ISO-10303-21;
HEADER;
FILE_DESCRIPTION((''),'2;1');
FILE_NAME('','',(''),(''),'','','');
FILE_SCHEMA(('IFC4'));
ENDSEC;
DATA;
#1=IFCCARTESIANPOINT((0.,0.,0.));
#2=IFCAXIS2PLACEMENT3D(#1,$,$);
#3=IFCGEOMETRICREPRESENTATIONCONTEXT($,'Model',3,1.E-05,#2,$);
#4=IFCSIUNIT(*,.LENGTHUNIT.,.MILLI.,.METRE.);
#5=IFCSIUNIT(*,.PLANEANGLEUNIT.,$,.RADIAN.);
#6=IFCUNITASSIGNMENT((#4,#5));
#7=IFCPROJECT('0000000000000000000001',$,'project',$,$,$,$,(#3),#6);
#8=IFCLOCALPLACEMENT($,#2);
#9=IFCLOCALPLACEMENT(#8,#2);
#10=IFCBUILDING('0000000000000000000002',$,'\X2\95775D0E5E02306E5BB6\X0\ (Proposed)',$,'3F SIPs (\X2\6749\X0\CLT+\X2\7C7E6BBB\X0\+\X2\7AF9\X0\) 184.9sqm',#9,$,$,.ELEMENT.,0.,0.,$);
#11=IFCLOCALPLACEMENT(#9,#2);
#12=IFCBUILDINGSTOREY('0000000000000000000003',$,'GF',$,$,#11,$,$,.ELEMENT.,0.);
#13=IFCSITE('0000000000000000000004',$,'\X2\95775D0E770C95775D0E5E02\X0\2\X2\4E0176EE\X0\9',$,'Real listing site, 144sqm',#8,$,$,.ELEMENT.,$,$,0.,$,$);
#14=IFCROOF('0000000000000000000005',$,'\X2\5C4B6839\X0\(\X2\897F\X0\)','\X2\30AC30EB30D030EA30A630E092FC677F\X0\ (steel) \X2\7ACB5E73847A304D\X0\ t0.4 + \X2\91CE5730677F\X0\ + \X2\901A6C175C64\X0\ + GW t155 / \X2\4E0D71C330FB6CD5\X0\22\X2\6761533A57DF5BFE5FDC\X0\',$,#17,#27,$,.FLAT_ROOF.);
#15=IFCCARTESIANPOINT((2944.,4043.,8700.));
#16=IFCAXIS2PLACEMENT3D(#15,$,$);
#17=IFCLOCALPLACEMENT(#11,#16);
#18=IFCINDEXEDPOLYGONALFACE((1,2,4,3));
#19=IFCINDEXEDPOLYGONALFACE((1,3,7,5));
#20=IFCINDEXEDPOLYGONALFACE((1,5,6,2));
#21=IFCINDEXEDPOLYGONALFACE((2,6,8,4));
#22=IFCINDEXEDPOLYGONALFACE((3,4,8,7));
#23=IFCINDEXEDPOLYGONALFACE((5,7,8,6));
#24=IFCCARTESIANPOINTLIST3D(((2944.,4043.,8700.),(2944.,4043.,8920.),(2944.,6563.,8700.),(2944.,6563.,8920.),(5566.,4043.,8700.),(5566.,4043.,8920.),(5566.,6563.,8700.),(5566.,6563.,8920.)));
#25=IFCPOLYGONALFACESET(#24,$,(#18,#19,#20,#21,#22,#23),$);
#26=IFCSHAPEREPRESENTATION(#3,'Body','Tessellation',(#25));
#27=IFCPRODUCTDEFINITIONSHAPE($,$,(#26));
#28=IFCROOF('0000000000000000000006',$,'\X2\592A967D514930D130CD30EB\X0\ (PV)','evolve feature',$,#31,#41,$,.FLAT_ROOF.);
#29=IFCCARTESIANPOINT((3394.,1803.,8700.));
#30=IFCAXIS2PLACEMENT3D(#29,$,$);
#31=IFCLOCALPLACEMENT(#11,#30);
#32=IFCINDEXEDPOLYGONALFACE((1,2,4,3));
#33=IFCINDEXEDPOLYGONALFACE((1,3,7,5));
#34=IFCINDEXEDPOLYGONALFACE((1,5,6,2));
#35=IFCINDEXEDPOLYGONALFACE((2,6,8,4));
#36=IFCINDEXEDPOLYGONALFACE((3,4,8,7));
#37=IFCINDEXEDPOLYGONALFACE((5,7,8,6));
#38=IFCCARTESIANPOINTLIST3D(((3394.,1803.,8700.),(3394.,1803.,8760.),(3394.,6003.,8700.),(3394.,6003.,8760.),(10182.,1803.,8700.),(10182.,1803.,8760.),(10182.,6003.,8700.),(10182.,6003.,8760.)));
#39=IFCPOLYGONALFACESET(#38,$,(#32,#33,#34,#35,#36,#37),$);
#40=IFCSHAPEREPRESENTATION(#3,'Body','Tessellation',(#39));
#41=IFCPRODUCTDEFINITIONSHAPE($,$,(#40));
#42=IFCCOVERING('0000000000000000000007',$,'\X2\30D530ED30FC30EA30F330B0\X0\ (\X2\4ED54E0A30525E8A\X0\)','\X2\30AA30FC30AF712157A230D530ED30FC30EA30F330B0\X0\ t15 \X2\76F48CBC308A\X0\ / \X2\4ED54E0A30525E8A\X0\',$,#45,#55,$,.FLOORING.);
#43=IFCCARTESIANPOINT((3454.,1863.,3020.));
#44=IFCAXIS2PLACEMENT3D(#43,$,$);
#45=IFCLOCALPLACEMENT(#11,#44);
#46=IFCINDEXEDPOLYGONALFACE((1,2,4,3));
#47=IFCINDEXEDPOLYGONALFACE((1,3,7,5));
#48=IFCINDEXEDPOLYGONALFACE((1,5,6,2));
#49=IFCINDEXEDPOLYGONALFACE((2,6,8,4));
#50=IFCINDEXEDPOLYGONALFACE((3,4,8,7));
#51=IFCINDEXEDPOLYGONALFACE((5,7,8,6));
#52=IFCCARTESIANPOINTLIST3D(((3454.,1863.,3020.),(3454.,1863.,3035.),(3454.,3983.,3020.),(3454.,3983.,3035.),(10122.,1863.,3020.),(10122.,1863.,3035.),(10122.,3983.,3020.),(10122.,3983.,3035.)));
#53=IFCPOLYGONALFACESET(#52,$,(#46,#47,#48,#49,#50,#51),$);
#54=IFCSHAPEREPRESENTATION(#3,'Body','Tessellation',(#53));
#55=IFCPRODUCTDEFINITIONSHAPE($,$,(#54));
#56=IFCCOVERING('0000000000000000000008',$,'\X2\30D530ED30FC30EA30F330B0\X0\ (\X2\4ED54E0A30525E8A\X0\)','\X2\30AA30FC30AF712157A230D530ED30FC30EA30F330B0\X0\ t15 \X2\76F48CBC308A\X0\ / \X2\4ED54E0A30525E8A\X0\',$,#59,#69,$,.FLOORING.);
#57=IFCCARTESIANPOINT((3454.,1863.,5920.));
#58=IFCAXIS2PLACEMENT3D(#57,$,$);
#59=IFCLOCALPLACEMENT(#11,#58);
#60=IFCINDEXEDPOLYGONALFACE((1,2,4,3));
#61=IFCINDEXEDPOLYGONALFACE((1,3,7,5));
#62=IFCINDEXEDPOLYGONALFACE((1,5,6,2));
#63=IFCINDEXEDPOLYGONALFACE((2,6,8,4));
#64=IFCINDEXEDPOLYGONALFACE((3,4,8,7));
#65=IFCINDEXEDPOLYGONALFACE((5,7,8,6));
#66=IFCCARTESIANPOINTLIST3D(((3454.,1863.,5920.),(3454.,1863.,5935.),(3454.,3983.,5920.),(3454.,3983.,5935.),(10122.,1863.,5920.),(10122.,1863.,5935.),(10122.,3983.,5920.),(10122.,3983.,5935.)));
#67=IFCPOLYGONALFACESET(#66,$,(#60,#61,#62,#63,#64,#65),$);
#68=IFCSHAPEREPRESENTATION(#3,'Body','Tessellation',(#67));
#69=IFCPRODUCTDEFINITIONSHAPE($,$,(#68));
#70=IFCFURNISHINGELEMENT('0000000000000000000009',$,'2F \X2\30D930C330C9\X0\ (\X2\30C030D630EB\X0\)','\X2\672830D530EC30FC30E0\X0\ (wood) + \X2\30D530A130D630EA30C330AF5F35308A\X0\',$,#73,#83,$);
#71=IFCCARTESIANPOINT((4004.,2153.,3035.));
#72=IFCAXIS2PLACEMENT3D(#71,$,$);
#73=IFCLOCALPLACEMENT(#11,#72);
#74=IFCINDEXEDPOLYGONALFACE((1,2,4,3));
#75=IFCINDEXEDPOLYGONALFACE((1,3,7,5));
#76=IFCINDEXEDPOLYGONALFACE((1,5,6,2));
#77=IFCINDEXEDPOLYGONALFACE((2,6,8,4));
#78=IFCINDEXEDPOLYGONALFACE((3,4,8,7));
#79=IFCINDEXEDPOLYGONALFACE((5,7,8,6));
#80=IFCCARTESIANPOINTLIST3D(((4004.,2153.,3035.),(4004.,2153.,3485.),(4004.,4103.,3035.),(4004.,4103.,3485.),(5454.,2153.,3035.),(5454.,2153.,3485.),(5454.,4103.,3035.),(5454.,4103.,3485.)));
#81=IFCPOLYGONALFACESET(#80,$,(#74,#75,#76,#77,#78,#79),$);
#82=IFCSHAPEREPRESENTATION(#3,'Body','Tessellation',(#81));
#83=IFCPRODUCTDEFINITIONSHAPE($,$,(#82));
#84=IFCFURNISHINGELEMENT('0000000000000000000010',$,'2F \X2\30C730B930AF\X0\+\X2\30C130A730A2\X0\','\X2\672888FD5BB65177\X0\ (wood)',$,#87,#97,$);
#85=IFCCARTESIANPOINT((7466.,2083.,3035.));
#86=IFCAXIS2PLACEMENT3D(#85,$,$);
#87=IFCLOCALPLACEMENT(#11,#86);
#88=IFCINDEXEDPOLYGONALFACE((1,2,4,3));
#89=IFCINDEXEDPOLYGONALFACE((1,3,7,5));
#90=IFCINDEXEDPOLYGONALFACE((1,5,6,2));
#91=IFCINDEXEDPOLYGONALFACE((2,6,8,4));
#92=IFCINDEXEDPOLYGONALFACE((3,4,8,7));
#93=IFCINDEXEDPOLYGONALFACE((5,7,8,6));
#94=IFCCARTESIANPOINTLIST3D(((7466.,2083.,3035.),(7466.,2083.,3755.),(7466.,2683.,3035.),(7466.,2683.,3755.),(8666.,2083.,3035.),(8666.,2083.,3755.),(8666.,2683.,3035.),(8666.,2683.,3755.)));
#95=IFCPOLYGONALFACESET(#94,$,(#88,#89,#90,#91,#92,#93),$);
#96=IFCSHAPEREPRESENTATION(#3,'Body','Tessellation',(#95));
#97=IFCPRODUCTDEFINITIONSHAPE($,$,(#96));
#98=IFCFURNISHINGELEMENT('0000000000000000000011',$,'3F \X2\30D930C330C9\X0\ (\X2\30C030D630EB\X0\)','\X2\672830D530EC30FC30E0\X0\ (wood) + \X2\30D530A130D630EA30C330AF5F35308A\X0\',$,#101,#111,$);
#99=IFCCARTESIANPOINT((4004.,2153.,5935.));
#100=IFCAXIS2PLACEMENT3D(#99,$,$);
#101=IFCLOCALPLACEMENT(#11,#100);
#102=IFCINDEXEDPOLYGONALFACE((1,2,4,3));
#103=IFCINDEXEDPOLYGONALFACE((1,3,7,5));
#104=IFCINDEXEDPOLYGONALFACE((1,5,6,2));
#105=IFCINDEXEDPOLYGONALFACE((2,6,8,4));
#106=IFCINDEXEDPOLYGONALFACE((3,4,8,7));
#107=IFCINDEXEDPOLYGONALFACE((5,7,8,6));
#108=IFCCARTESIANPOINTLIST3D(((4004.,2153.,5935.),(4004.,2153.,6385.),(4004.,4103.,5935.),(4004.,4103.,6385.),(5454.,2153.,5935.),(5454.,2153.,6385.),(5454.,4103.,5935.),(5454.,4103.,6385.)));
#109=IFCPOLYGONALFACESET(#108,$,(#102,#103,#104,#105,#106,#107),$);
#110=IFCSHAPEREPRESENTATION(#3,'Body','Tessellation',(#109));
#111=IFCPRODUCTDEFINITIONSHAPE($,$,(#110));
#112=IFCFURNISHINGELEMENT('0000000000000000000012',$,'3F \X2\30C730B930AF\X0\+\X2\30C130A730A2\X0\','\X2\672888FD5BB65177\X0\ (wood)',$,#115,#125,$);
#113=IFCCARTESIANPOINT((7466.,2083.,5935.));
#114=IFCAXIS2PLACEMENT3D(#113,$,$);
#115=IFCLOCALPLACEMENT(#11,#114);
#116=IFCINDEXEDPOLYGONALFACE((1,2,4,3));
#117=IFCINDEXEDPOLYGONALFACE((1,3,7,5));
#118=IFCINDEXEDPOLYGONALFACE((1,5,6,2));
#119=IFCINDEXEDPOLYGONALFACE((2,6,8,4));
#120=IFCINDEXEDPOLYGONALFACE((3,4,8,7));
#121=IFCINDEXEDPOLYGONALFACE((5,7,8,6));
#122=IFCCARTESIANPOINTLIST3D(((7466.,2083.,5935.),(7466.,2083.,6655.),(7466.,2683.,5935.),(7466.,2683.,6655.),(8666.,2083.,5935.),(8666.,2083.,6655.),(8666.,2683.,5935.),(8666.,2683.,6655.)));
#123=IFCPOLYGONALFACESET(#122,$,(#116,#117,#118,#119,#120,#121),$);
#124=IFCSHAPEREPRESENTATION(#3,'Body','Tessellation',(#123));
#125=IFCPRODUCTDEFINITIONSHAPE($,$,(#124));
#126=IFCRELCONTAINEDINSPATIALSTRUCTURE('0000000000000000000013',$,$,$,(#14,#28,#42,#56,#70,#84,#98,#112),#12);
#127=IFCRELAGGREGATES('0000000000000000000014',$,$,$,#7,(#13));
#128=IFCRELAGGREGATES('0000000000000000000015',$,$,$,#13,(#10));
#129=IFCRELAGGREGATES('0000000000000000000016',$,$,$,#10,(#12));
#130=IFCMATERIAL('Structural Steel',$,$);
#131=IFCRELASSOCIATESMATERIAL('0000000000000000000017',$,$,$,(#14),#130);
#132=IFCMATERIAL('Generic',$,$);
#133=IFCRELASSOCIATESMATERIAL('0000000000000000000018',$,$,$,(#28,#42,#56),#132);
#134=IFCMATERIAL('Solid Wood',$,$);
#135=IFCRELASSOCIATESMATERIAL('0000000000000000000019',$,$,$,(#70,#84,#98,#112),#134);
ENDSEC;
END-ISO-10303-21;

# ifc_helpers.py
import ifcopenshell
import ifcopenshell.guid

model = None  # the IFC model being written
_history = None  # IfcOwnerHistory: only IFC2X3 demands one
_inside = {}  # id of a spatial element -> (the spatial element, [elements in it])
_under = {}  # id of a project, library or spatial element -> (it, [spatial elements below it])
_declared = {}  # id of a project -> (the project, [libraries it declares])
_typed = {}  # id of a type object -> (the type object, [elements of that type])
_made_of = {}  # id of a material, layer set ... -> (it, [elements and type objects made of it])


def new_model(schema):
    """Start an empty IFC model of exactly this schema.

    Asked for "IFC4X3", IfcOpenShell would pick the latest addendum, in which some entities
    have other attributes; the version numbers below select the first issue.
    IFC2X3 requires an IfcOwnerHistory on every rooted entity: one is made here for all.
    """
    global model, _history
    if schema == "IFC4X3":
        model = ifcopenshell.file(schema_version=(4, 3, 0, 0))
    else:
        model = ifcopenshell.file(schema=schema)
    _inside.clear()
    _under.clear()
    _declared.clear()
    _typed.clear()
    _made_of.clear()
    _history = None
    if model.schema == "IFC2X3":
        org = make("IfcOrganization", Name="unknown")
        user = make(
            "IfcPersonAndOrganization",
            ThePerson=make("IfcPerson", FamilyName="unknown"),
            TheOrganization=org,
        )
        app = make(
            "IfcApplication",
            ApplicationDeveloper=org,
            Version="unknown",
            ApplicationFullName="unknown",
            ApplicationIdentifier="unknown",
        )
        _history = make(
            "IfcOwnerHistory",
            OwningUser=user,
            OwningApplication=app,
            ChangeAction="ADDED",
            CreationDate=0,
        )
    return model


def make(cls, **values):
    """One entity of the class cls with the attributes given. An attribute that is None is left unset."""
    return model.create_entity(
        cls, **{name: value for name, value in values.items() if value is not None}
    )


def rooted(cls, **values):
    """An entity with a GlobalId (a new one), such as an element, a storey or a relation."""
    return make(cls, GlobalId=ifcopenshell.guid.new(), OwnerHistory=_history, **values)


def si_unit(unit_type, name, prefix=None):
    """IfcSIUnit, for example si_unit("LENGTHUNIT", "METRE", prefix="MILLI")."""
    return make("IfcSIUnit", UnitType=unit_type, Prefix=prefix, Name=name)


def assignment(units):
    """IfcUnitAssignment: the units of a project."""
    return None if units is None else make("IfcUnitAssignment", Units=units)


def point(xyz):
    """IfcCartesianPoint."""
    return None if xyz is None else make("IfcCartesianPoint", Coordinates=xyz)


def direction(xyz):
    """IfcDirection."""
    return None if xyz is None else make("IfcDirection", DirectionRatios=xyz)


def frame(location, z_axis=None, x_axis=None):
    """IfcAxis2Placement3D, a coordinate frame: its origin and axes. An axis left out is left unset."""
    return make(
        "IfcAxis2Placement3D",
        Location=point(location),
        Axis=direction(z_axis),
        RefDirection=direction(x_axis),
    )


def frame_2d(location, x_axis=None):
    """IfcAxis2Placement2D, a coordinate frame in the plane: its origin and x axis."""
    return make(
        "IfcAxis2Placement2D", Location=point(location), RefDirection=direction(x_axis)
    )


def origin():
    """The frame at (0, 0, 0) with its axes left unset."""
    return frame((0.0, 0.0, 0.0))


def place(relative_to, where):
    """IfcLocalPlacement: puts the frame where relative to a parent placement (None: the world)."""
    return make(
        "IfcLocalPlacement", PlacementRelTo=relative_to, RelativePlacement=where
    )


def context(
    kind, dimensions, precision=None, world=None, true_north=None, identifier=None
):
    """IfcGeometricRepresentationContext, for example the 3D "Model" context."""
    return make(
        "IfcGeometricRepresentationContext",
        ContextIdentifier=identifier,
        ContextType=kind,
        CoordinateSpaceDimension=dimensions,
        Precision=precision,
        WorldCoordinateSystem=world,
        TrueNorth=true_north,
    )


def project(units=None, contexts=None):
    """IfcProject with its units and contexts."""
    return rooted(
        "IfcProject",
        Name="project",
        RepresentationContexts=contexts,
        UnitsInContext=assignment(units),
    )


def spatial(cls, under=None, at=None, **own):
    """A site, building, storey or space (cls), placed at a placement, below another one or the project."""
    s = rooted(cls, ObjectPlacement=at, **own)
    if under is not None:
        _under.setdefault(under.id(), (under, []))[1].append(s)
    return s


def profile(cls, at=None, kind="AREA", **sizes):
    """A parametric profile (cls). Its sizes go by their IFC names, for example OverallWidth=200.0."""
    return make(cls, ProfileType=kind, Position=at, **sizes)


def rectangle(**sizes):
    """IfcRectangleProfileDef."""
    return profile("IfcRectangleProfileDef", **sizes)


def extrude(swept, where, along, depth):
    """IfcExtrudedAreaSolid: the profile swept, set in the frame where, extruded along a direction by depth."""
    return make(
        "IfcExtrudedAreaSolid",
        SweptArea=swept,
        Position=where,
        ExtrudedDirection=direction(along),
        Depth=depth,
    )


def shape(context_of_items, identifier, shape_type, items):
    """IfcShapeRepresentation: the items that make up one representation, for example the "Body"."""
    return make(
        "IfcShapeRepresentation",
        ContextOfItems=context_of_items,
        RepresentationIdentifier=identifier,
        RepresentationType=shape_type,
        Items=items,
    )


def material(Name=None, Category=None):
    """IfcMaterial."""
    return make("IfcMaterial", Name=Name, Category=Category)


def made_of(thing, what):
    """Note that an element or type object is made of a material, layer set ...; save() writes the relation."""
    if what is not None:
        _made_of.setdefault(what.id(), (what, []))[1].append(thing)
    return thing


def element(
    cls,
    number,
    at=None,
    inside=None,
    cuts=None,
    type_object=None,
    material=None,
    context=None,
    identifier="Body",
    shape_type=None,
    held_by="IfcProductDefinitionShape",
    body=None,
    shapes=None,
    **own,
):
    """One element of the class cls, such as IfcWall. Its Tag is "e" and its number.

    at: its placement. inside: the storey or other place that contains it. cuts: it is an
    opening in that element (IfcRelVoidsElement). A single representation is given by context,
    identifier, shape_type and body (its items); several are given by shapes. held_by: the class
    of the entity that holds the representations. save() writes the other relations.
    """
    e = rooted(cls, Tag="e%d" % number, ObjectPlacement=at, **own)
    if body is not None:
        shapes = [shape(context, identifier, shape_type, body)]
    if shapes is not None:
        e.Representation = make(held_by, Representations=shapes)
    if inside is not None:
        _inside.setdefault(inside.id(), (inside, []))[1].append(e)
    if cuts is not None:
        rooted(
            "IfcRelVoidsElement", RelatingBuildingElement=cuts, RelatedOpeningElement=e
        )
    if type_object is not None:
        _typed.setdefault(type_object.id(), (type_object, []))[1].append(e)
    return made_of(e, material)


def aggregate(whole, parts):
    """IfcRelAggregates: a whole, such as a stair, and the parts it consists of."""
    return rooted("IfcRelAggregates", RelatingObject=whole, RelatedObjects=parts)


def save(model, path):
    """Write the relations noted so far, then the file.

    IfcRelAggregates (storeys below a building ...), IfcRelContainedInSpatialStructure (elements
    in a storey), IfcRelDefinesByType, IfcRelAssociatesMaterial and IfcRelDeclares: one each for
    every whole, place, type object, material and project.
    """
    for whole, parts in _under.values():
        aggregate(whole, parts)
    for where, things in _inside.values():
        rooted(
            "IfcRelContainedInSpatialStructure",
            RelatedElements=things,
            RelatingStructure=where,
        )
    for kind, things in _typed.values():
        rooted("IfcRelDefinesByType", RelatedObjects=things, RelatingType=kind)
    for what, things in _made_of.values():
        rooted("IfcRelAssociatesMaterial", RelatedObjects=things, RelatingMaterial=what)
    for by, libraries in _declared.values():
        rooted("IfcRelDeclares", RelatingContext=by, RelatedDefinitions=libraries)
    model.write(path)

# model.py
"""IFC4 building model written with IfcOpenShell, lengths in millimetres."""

from ifc_helpers import new_model, si_unit, frame, frame_2d, origin, place, context, project, spatial, rectangle, extrude, material, element, save


model = new_model("IFC4")

# Units and contexts
model_context = context("Model", 3, precision=1e-05, world=origin())
ifc_project = project(units=[si_unit("LENGTHUNIT", "METRE", prefix="MILLI"), si_unit("PLANEANGLEUNIT", "RADIAN")], contexts=[model_context])

# Site, building, storey
site_placement = place(None, origin())
site = spatial("IfcSite", under=ifc_project, at=site_placement, Name="長崎県長崎市2丁目9", ObjectType="Real listing site, 144sqm", CompositionType="ELEMENT", RefElevation=0.0)
building_placement = place(site_placement, origin())
building = spatial("IfcBuilding", under=site, at=building_placement, Name="長崎市の家 (Proposed)", ObjectType="3F SIPs (杉CLT+籾殻+竹) 184.9sqm", CompositionType="ELEMENT", ElevationOfRefHeight=0.0, ElevationOfTerrain=0.0)
storey_placement = place(building_placement, origin())
storey = spatial("IfcBuildingStorey", under=building, at=storey_placement, Name="GF", CompositionType="ELEMENT", Elevation=0.0)

# Shared definitions
ifc_material_1 = material(Name="Solid Wood")

# Roofs
ifc_material_2 = material(Name="Structural Steel")
roof_1_placement = place(storey_placement, frame((2944.0, 4043.0, 8700.0)))
element("IfcRoof", 1, at=roof_1_placement, inside=storey, material=ifc_material_2, Name="屋根(西)", Description="ガルバリウム鋼板 (steel) 立平葺き t0.4 + 野地板 + 通気層 + GW t155 / 不燃・法22条区域対応", PredefinedType="FLAT_ROOF", context=model_context, shape_type="SweptSolid", body=[
    extrude(rectangle(XDim=2622.0, YDim=2520.0, at=frame_2d((1311.0, 1260.0))), frame((2944.0, 4043.0, 8700.0)), (0.0, 0.0, 1.0), 220.0),
])
ifc_material_3 = material(Name="Generic")
roof_2_placement = place(storey_placement, frame((3394.0, 1803.0, 8700.0)))
element("IfcRoof", 2, at=roof_2_placement, inside=storey, material=ifc_material_3, Name="太陽光パネル (PV)", Description="evolve feature", PredefinedType="FLAT_ROOF", context=model_context, shape_type="SweptSolid", body=[
    extrude(rectangle(XDim=6788.0, YDim=4200.0, at=frame_2d((3394.0, 2100.0))), frame((3394.0, 1803.0, 8700.0)), (0.0, 0.0, 1.0), 60.0),
])

# Coverings
covering_1_placement = place(storey_placement, frame((3454.0, 1863.0, 3020.0)))
element("IfcCovering", 3, at=covering_1_placement, inside=storey, material=ifc_material_3, Name="フローリング (仕上げ床)", Description="オーク無垢フローリング t15 直貼り / 仕上げ床", PredefinedType="FLOORING", context=model_context, shape_type="SweptSolid", body=[
    extrude(rectangle(XDim=6668.0, YDim=2120.0, at=frame_2d((3334.0, 1060.0))), frame((3454.0, 1863.0, 3020.0)), (0.0, 0.0, 1.0), 15.0),
])
covering_2_placement = place(storey_placement, frame((3454.0, 1863.0, 5920.0)))
element("IfcCovering", 4, at=covering_2_placement, inside=storey, material=ifc_material_3, Name="フローリング (仕上げ床)", Description="オーク無垢フローリング t15 直貼り / 仕上げ床", PredefinedType="FLOORING", context=model_context, shape_type="SweptSolid", body=[
    extrude(rectangle(XDim=6668.0, YDim=2120.0, at=frame_2d((3334.0, 1060.0))), frame((3454.0, 1863.0, 5920.0)), (0.0, 0.0, 1.0), 15.0),
])

# Furnishing elements
furnishing_1_placement = place(storey_placement, frame((4004.0, 2153.0, 3035.0)))
element("IfcFurnishingElement", 5, at=furnishing_1_placement, inside=storey, material=ifc_material_1, Name="2F ベッド (ダブル)", Description="木フレーム (wood) + ファブリック張り", context=model_context, shape_type="SweptSolid", body=[
    extrude(rectangle(XDim=1450.0, YDim=1950.0, at=frame_2d((725.0, 975.0))), frame((4004.0, 2153.0, 3035.0)), (0.0, 0.0, 1.0), 450.0),
])
furnishing_2_placement = place(storey_placement, frame((7466.0, 2083.0, 3035.0)))
element("IfcFurnishingElement", 6, at=furnishing_2_placement, inside=storey, material=ifc_material_1, Name="2F デスク+チェア", Description="木製家具 (wood)", context=model_context, shape_type="SweptSolid", body=[
    extrude(rectangle(XDim=1200.0, YDim=600.0, at=frame_2d((600.0, 300.0))), frame((7466.0, 2083.0, 3035.0)), (0.0, 0.0, 1.0), 720.0),
])
furnishing_3_placement = place(storey_placement, frame((4004.0, 2153.0, 5935.0)))
element("IfcFurnishingElement", 7, at=furnishing_3_placement, inside=storey, material=ifc_material_1, Name="3F ベッド (ダブル)", Description="木フレーム (wood) + ファブリック張り", context=model_context, shape_type="SweptSolid", body=[
    extrude(rectangle(XDim=1450.0, YDim=1950.0, at=frame_2d((725.0, 975.0))), frame((4004.0, 2153.0, 5935.0)), (0.0, 0.0, 1.0), 450.0),
])
furnishing_4_placement = place(storey_placement, frame((7466.0, 2083.0, 5935.0)))
element("IfcFurnishingElement", 8, at=furnishing_4_placement, inside=storey, material=ifc_material_1, Name="3F デスク+チェア", Description="木製家具 (wood)", context=model_context, shape_type="SweptSolid", body=[
    extrude(rectangle(XDim=1200.0, YDim=600.0, at=frame_2d((600.0, 300.0))), frame((7466.0, 2083.0, 5935.0)), (0.0, 0.0, 1.0), 720.0),
])

save(model, "model.ifc")
